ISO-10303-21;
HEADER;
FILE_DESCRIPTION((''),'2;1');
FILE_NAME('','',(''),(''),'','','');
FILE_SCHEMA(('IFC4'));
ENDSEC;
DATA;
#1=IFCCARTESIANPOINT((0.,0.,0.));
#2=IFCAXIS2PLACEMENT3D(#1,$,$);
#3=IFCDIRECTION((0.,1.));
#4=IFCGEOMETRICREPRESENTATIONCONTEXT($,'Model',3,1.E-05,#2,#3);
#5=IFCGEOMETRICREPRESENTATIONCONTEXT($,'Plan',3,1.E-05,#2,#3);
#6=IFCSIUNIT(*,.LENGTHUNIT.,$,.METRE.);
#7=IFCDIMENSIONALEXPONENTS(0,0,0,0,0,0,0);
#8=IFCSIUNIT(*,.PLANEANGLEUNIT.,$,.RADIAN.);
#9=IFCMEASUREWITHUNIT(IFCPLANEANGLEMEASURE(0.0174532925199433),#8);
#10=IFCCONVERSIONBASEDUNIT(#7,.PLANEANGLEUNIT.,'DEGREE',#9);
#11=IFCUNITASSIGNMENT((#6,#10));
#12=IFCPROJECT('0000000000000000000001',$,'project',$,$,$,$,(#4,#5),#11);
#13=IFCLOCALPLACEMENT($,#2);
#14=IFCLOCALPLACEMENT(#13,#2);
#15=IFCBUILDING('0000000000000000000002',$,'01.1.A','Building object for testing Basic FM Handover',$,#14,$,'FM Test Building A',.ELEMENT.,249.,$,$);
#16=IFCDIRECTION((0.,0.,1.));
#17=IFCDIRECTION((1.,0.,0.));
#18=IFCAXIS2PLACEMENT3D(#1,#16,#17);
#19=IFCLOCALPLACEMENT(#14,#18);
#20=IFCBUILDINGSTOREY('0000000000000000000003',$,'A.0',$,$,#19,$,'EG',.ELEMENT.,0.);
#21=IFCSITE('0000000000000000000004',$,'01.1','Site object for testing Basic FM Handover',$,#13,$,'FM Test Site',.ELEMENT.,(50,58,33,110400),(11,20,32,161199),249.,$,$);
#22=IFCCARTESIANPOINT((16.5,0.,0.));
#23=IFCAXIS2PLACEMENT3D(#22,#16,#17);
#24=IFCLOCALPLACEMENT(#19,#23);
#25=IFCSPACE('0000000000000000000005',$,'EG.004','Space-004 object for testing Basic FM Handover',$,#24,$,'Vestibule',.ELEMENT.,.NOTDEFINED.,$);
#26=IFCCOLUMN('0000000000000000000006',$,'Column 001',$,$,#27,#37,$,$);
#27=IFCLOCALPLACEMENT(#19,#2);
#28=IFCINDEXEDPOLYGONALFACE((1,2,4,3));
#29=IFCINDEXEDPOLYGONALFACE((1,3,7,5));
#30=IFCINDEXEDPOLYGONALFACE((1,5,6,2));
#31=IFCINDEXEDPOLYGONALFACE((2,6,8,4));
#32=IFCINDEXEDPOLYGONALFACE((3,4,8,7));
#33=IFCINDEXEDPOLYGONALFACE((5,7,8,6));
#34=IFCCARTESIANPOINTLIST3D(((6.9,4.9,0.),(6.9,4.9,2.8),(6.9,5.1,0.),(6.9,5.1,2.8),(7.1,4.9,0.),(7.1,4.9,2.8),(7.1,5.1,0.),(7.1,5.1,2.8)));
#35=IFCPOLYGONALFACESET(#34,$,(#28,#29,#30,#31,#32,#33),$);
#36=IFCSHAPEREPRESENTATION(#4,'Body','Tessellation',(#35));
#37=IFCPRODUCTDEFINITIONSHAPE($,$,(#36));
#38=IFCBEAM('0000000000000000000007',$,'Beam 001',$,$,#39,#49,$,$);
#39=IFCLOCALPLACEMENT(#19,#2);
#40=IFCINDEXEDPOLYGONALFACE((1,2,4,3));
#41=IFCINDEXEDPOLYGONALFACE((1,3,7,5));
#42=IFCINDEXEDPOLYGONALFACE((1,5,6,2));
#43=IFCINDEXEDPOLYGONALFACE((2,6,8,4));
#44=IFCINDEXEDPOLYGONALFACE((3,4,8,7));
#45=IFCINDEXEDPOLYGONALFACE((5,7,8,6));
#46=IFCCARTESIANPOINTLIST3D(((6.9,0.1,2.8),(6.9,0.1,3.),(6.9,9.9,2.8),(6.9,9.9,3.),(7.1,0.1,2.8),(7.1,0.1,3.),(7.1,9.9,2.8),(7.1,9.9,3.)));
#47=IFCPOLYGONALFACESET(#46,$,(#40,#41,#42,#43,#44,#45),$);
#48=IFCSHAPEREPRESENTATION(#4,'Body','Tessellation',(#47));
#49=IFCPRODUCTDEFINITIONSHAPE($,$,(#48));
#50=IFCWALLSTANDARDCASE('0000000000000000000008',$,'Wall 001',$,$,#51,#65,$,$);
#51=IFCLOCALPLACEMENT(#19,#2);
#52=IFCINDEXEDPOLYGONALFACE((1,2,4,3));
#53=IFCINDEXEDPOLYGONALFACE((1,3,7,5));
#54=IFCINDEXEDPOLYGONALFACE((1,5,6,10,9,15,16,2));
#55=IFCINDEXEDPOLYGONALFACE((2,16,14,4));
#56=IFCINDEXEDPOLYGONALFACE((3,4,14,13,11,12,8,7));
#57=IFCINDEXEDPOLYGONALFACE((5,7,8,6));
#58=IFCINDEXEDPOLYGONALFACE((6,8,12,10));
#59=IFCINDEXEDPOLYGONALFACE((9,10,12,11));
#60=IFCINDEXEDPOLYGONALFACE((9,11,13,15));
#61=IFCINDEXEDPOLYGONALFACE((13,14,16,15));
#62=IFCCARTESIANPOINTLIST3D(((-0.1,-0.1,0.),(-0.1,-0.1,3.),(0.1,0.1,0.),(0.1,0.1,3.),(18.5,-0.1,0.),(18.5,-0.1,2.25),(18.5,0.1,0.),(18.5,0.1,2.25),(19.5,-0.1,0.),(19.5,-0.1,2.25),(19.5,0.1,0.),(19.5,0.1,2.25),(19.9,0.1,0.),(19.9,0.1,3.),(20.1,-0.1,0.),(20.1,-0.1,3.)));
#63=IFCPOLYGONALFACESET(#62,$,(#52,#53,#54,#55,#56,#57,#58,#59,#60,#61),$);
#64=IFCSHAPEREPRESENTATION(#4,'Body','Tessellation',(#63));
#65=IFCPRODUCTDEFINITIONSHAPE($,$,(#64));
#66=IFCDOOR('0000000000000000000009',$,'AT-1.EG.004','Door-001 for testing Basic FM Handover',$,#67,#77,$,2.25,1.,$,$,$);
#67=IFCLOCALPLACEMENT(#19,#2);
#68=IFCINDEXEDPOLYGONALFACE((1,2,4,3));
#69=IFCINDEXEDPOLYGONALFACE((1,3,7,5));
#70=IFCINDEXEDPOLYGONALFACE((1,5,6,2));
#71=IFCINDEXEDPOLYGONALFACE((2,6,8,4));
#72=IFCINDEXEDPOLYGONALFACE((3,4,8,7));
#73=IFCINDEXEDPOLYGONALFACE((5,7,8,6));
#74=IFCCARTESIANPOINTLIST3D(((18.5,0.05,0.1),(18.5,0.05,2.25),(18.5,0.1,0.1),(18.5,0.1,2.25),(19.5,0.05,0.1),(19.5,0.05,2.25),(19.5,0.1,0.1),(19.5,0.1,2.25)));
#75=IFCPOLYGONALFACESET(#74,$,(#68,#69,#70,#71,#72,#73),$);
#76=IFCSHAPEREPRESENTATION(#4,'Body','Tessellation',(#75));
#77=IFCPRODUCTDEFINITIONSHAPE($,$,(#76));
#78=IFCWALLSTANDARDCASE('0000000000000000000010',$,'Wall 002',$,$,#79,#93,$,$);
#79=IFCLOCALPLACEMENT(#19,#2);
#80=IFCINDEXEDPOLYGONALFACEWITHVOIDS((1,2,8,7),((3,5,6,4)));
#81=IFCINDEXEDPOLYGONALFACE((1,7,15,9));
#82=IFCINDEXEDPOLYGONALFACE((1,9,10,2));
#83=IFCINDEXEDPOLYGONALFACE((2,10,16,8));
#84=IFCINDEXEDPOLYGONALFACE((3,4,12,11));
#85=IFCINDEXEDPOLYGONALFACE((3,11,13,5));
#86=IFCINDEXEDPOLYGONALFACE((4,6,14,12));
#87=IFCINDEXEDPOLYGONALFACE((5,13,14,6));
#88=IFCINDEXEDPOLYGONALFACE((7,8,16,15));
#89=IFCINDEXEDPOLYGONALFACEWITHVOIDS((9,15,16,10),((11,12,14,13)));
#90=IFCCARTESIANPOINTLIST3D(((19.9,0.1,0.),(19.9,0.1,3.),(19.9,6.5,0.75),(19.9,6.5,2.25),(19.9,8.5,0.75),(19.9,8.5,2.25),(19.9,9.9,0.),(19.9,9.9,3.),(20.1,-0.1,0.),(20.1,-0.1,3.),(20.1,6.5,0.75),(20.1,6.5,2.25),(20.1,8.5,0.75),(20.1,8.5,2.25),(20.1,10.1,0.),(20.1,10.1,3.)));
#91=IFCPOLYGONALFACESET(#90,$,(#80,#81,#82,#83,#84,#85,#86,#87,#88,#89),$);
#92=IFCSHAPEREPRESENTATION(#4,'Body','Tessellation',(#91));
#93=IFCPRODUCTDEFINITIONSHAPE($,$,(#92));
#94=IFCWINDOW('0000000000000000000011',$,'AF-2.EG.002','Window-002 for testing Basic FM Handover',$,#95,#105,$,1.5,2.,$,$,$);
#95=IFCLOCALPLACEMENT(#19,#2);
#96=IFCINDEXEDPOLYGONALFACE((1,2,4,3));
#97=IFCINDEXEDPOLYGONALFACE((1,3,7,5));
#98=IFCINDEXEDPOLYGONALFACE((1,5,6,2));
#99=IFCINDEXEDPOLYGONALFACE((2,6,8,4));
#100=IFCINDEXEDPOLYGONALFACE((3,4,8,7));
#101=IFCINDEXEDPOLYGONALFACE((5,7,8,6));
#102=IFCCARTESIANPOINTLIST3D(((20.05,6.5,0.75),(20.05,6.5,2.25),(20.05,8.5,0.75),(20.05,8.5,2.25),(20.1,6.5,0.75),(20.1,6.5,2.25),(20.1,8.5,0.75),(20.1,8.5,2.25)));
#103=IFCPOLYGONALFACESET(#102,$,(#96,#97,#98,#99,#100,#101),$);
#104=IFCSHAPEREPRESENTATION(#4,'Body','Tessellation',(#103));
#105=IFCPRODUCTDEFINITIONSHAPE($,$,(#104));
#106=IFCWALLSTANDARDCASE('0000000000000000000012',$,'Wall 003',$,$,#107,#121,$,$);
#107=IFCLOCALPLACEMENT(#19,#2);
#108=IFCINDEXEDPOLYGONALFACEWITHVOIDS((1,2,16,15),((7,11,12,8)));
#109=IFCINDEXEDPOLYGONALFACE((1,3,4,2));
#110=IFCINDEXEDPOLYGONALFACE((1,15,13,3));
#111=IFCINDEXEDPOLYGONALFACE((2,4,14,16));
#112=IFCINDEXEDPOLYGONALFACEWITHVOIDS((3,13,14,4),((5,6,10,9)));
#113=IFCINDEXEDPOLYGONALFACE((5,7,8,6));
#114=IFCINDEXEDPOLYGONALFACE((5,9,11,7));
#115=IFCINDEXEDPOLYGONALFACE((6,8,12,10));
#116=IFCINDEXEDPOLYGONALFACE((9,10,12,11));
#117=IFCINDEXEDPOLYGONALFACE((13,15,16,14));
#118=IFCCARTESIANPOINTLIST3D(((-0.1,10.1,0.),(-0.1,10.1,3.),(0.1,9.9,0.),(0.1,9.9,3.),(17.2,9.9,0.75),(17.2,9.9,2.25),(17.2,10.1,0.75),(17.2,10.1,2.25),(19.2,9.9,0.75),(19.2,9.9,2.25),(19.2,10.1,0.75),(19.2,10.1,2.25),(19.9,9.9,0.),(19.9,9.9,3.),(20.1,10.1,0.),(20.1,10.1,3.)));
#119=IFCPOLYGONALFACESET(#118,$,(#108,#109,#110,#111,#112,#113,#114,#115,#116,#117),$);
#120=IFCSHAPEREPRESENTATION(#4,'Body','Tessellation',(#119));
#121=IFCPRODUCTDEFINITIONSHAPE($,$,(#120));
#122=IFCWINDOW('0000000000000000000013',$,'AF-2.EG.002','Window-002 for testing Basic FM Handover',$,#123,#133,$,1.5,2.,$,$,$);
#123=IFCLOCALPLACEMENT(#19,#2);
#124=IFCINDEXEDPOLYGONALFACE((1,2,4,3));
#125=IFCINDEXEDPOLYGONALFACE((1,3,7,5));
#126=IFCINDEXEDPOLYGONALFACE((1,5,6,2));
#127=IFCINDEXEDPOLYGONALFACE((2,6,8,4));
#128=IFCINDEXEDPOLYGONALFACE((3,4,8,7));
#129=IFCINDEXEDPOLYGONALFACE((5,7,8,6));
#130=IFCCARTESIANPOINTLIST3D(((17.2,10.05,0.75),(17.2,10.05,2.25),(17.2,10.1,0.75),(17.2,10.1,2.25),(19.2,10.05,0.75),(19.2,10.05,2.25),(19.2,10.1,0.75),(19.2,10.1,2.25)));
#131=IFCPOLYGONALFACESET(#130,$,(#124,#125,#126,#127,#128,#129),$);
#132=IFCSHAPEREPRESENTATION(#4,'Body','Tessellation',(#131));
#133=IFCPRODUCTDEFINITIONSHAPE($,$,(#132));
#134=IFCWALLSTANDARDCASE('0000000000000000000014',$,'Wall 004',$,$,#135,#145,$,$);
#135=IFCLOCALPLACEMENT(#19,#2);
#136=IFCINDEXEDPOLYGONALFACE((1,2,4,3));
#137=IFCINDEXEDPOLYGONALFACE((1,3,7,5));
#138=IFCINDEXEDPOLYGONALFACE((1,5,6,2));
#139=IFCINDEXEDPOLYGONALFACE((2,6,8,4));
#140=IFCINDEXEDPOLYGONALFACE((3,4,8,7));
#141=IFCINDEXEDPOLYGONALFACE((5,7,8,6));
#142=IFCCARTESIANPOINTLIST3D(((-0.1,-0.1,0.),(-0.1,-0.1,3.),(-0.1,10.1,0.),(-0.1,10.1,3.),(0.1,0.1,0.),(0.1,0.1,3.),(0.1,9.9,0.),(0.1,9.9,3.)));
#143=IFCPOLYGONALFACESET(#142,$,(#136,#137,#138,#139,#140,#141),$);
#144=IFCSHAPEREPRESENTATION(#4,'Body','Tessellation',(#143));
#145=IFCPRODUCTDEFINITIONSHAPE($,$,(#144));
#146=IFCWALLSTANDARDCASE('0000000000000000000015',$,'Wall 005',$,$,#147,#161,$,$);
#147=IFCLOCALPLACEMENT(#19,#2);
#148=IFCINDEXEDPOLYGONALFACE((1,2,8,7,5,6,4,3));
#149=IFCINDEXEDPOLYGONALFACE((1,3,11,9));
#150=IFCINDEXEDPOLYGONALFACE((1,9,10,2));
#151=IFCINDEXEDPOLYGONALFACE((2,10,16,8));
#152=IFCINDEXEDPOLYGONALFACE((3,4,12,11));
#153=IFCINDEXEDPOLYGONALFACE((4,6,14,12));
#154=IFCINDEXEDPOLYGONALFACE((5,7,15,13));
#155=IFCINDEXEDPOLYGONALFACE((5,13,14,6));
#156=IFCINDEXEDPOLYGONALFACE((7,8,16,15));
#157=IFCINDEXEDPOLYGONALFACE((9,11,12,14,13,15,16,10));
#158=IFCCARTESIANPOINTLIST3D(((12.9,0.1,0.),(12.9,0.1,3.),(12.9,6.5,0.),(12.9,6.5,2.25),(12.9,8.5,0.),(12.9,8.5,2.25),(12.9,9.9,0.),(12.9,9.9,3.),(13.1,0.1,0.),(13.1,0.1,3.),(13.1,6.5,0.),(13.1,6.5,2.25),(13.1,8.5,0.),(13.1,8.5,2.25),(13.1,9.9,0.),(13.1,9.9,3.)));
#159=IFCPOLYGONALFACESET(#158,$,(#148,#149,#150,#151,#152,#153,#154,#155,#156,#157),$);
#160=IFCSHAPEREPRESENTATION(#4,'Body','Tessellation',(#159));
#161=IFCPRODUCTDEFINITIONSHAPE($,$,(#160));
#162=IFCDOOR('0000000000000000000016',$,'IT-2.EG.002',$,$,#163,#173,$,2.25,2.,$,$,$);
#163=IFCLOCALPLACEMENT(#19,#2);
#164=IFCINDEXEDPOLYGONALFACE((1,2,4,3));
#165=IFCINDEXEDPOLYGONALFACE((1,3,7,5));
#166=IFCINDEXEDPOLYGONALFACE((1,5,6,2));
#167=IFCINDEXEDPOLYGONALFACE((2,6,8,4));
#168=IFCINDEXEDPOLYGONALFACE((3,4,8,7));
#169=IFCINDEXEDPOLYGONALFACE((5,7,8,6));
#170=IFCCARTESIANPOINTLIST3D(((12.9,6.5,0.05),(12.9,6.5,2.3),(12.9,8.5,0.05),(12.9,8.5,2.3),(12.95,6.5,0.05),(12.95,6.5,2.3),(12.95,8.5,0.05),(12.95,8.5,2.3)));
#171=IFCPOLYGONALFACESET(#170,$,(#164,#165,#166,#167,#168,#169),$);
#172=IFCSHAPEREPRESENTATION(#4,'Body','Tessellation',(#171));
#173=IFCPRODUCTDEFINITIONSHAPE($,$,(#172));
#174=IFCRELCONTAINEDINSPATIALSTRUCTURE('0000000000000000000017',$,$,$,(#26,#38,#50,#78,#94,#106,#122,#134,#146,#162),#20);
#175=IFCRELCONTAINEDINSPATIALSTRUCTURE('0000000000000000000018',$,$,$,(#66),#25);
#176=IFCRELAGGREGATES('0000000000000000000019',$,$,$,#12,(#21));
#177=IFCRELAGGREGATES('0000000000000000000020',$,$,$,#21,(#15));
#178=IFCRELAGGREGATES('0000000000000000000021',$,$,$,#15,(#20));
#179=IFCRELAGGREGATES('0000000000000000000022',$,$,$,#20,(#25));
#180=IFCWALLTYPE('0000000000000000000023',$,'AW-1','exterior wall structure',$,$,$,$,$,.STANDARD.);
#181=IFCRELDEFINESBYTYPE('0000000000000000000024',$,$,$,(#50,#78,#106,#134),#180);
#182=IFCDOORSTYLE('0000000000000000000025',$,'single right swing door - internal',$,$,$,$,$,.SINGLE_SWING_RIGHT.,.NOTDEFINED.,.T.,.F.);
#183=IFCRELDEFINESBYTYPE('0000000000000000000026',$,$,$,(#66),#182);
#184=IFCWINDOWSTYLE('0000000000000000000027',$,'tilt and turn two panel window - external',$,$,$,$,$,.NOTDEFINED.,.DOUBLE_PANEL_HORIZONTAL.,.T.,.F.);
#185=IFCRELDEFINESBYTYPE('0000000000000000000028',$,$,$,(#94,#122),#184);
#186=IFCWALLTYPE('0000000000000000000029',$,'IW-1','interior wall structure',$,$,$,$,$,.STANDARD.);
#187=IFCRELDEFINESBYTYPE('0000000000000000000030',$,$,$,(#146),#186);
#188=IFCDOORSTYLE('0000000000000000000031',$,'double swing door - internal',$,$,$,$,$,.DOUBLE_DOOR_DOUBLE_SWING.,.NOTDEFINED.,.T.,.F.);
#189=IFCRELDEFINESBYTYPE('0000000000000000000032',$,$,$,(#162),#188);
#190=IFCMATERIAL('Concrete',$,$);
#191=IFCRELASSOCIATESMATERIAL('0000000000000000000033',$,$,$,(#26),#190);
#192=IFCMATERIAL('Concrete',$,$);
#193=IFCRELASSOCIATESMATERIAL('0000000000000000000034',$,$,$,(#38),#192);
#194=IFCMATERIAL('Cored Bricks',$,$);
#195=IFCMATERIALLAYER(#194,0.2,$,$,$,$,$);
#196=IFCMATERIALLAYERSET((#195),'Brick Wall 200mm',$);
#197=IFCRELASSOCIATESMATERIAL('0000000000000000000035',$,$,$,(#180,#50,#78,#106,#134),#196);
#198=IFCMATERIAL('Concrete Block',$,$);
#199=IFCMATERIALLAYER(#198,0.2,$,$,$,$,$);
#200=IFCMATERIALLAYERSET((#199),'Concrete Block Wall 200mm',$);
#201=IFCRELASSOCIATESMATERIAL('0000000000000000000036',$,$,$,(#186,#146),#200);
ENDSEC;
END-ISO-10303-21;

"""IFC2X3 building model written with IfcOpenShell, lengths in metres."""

from ifc_helpers import new_model, entity, si_unit, converted_unit, direction, frame, frame_2d, origin, origin_with_axes, origin_2d, place, context, project, spatial, polyline, rectangle, outline, extrude, material, layer, layer_set, layer_usage, type_object, element, fill, save


model = new_model("IFC2X3")

# Units and contexts
model_context = context("Model", 3, precision=1e-05, world=origin(), true_north=direction((0.0, 1.0)))
plan_context = context("Plan", 3, precision=1e-05, world=origin(), true_north=direction((0.0, 1.0)))
ifc_project = project(units=[si_unit("LENGTHUNIT", "METRE"), converted_unit("PLANEANGLEUNIT", "DEGREE", entity("IfcPlaneAngleMeasure", 0.0174532925199433), si_unit("PLANEANGLEUNIT", "RADIAN"), dimensions=[0, 0, 0, 0, 0, 0, 0])], contexts=[model_context, plan_context])

# Site, building, storey
site_placement = place(None, origin())
site = spatial("IfcSite", under=ifc_project, at=site_placement, Name="01.1", Description="Site object for testing Basic FM Handover", LongName="FM Test Site", CompositionType="ELEMENT", RefLatitude=(50, 58, 33, 110400), RefLongitude=(11, 20, 32, 161199), RefElevation=249.0)
building_placement = place(site_placement, origin())
building = spatial("IfcBuilding", under=site, at=building_placement, Name="01.1.A", Description="Building object for testing Basic FM Handover", LongName="FM Test Building A", CompositionType="ELEMENT", ElevationOfRefHeight=249.0)
storey_placement = place(building_placement, origin_with_axes())
storey = spatial("IfcBuildingStorey", under=building, at=storey_placement, Name="A.0", LongName="EG", CompositionType="ELEMENT", Elevation=0.0)

# Column
ifc_material_1 = material(Name="Concrete")
column_placement = place(storey_placement, frame((7.0, 5.0, 0.0), z_axis=(0.0, 0.0, 1.0), x_axis=(1.0, 0.0, 0.0)))
element("IfcColumn", 1, at=column_placement, inside=storey, material=ifc_material_1, Name="Column 001", context=model_context, shape_type="SweptSolid", body=[
    extrude(rectangle(XDim=0.2, YDim=0.2, at=origin_2d()), origin(), (0.0, 0.0, 1.0), 2.8),
])

# Beam
ifc_material_2 = material(Name="Concrete")
beam_placement = place(storey_placement, frame((7.0, 9.9, 2.9), z_axis=(0.0, -1.0, 0.0), x_axis=(1.0, 0.0, 0.0)))
element("IfcBeam", 2, at=beam_placement, inside=storey, material=ifc_material_2, Name="Beam 001", context=model_context, shape_type="SweptSolid", body=[
    extrude(rectangle(XDim=0.2, YDim=0.2, at=origin_2d()), origin(), (0.0, 0.0, 1.0), 9.8),
])

# Wall, opening
ifc_material_3 = material(Name="Cored Bricks")
ifc_layer_1 = layer(ifc_material_3, 0.2)
ifc_layer_set_1 = layer_set([ifc_layer_1], Name="Brick Wall 200mm")
ifc_layer_usage_1 = layer_usage(ifc_layer_set_1, "AXIS2", "POSITIVE", -0.1)
wall_type_1 = type_object("IfcWallType", Name="AW-1", Description="exterior wall structure", PredefinedType="STANDARD", material=ifc_layer_set_1)
wall_1_placement = place(storey_placement, origin_with_axes())
wall_1 = element("IfcWallStandardCase", 3, at=wall_1_placement, inside=storey, type_object=wall_type_1, material=ifc_layer_usage_1, Name="Wall 001", context=model_context, shape_type="SweptSolid", body=[
    extrude(outline(polyline([(-0.1, -0.1), (20.1, -0.1), (19.9, 0.1), (0.1, 0.1), (-0.1, -0.1)])), origin(), (0.0, 0.0, 1.0), 3.0),
])
opening_1_placement = place(wall_1_placement, frame((18.5, -0.1, 0.0), z_axis=(0.0, 1.0, 0.0), x_axis=(0.0, 0.0, 1.0)))
opening_1 = element("IfcOpeningElement", 4, at=opening_1_placement, cuts=wall_1, context=model_context, shape_type="SweptSolid", body=[
    extrude(rectangle(XDim=2.25, YDim=1.0, at=frame_2d((1.125, 0.5))), origin(), (0.0, 0.0, 1.0), 0.2),
])

# Shared definitions
space_1_placement = place(storey_placement, frame((16.5, 0.0, 0.0), z_axis=(0.0, 0.0, 1.0), x_axis=(1.0, 0.0, 0.0)))
space_1 = spatial("IfcSpace", under=storey, at=space_1_placement, Name="EG.004", Description="Space-004 object for testing Basic FM Handover", LongName="Vestibule", CompositionType="ELEMENT", InteriorOrExteriorSpace="NOTDEFINED")

# Door
door_style_1 = type_object("IfcDoorStyle", Name="single right swing door - internal", ConstructionType="NOTDEFINED", OperationType="SINGLE_SWING_RIGHT", ParameterTakesPrecedence=True, Sizeable=False)
door_1_placement = place(opening_1_placement, frame((0.0, 0.0, 0.0), z_axis=(1.0, 0.0, 0.0), x_axis=(0.0, 1.0, 0.0)))
door_1 = element("IfcDoor", 5, at=door_1_placement, inside=space_1, type_object=door_style_1, Name="AT-1.EG.004", Description="Door-001 for testing Basic FM Handover", OverallHeight=2.25, OverallWidth=1.0, context=model_context, shape_type="SweptSolid", body=[
    extrude(rectangle(XDim=2.15, YDim=1.0, at=frame_2d((1.075, 0.5))), frame((0.0, 0.15, 0.1), z_axis=(0.0, 1.0, 0.0), x_axis=(0.0, 0.0, 1.0)), (0.0, 0.0, 1.0), 0.05),
])
fill(opening_1, door_1)

# Walls, openings, windows
ifc_layer_usage_2 = layer_usage(ifc_layer_set_1, "AXIS2", "POSITIVE", -0.1)
wall_2_placement = place(storey_placement, frame((20.0, 0.0, 0.0), z_axis=(0.0, 0.0, 1.0), x_axis=(0.0, 1.0, 0.0)))
wall_2 = element("IfcWallStandardCase", 6, at=wall_2_placement, inside=storey, type_object=wall_type_1, material=ifc_layer_usage_2, Name="Wall 002", context=model_context, shape_type="SweptSolid", body=[
    extrude(outline(polyline([(-0.1, -0.1), (10.1, -0.1), (9.9, 0.1), (0.1, 0.1), (-0.1, -0.1)])), origin(), (0.0, 0.0, 1.0), 3.0),
])
opening_2_placement = place(wall_2_placement, frame((6.5, -0.1, 0.75), z_axis=(0.0, 0.0, 1.0), x_axis=(1.0, 0.0, 0.0)))
opening_2 = element("IfcOpeningElement", 7, at=opening_2_placement, cuts=wall_2, context=model_context, shape_type="SweptSolid", body=[
    extrude(rectangle(XDim=1.5, YDim=2.0, at=frame_2d((0.75, 1.0))), frame((0.0, 0.0, 0.0), z_axis=(0.0, 1.0, 0.0), x_axis=(0.0, 0.0, 1.0)), (0.0, 0.0, 1.0), 0.2),
])
window_style = type_object("IfcWindowStyle", Name="tilt and turn two panel window - external", ConstructionType="NOTDEFINED", OperationType="DOUBLE_PANEL_HORIZONTAL", ParameterTakesPrecedence=True, Sizeable=False)
window_1_placement = place(opening_2_placement, origin_with_axes())
window_1 = element("IfcWindow", 8, at=window_1_placement, inside=storey, type_object=window_style, Name="AF-2.EG.002", Description="Window-002 for testing Basic FM Handover", OverallHeight=1.5, OverallWidth=2.0, context=model_context, shape_type="SweptSolid", body=[
    extrude(rectangle(XDim=1.5, YDim=2.0, at=frame_2d((0.75, 1.0))), frame((0.0, 0.0, 0.0), z_axis=(0.0, 1.0, 0.0), x_axis=(0.0, 0.0, 1.0)), (0.0, 0.0, 1.0), 0.05),
])
fill(opening_2, window_1)
ifc_layer_usage_3 = layer_usage(ifc_layer_set_1, "AXIS2", "POSITIVE", -0.1)
wall_3_placement = place(storey_placement, frame((20.0, 10.0, 0.0), z_axis=(0.0, 0.0, 1.0), x_axis=(-1.0, 0.0, 0.0)))
wall_3 = element("IfcWallStandardCase", 9, at=wall_3_placement, inside=storey, type_object=wall_type_1, material=ifc_layer_usage_3, Name="Wall 003", context=model_context, shape_type="SweptSolid", body=[
    extrude(outline(polyline([(-0.1, -0.1), (20.1, -0.1), (19.9, 0.1), (0.1, 0.1), (-0.1, -0.1)])), origin(), (0.0, 0.0, 1.0), 3.0),
])
opening_3_placement = place(wall_3_placement, frame((0.8, -0.1, 0.75), z_axis=(0.0, 0.0, 1.0), x_axis=(1.0, 0.0, 0.0)))
opening_3 = element("IfcOpeningElement", 10, at=opening_3_placement, cuts=wall_3, context=model_context, shape_type="SweptSolid", body=[
    extrude(rectangle(XDim=1.5, YDim=2.0, at=frame_2d((0.75, 1.0))), frame((0.0, 0.0, 0.0), z_axis=(0.0, 1.0, 0.0), x_axis=(0.0, 0.0, 1.0)), (0.0, 0.0, 1.0), 0.2),
])
window_2_placement = place(opening_3_placement, origin_with_axes())
window_2 = element("IfcWindow", 11, at=window_2_placement, inside=storey, type_object=window_style, Name="AF-2.EG.002", Description="Window-002 for testing Basic FM Handover", OverallHeight=1.5, OverallWidth=2.0, context=model_context, shape_type="SweptSolid", body=[
    extrude(rectangle(XDim=1.5, YDim=2.0, at=frame_2d((0.75, 1.0))), frame((0.0, 0.0, 0.0), z_axis=(0.0, 1.0, 0.0), x_axis=(0.0, 0.0, 1.0)), (0.0, 0.0, 1.0), 0.05),
])
fill(opening_3, window_2)

# Wall
ifc_layer_usage_4 = layer_usage(ifc_layer_set_1, "AXIS2", "POSITIVE", -0.1)
wall_4_placement = place(storey_placement, frame((0.0, 10.0, 0.0), z_axis=(0.0, 0.0, 1.0), x_axis=(0.0, -1.0, 0.0)))
element("IfcWallStandardCase", 12, at=wall_4_placement, inside=storey, type_object=wall_type_1, material=ifc_layer_usage_4, Name="Wall 004", context=model_context, shape_type="SweptSolid", body=[
    extrude(outline(polyline([(-0.1, -0.1), (10.1, -0.1), (9.9, 0.1), (0.1, 0.1), (-0.1, -0.1)])), origin(), (0.0, 0.0, 1.0), 3.0),
])

# Wall, opening, door
ifc_material_4 = material(Name="Concrete Block")
ifc_layer_2 = layer(ifc_material_4, 0.2)
ifc_layer_set_2 = layer_set([ifc_layer_2], Name="Concrete Block Wall 200mm")
ifc_layer_usage_5 = layer_usage(ifc_layer_set_2, "AXIS2", "POSITIVE", -0.1)
wall_type_2 = type_object("IfcWallType", Name="IW-1", Description="interior wall structure", PredefinedType="STANDARD", material=ifc_layer_set_2)
wall_5_placement = place(storey_placement, frame((13.0, 0.0, 0.0), z_axis=(0.0, 0.0, 1.0), x_axis=(0.0, 1.0, 0.0)))
wall_5 = element("IfcWallStandardCase", 13, at=wall_5_placement, inside=storey, type_object=wall_type_2, material=ifc_layer_usage_5, Name="Wall 005", context=model_context, shape_type="SweptSolid", body=[
    extrude(outline(polyline([(0.1, -0.1), (9.9, -0.1), (9.9, 0.1), (0.1, 0.1), (0.1, -0.1)])), origin(), (0.0, 0.0, 1.0), 3.0),
])
opening_4_placement = place(wall_5_placement, frame((6.5, -0.1, 0.0), z_axis=(0.0, 0.0, 1.0), x_axis=(1.0, 0.0, 0.0)))
opening_4 = element("IfcOpeningElement", 14, at=opening_4_placement, cuts=wall_5, context=model_context, shape_type="SweptSolid", body=[
    extrude(rectangle(XDim=2.25, YDim=2.0, at=frame_2d((1.125, 1.0))), frame((0.0, 0.0, 0.0), z_axis=(0.0, 1.0, 0.0), x_axis=(0.0, 0.0, 1.0)), (0.0, 0.0, 1.0), 0.2),
])
door_style_2 = type_object("IfcDoorStyle", Name="double swing door - internal", ConstructionType="NOTDEFINED", OperationType="DOUBLE_DOOR_DOUBLE_SWING", ParameterTakesPrecedence=True, Sizeable=False)
door_2_placement = place(opening_4_placement, origin_with_axes())
door_2 = element("IfcDoor", 15, at=door_2_placement, inside=storey, type_object=door_style_2, Name="IT-2.EG.002", OverallHeight=2.25, OverallWidth=2.0, context=model_context, shape_type="SweptSolid", body=[
    extrude(rectangle(XDim=2.25, YDim=2.0, at=frame_2d((1.075, 1.0))), frame((0.0, 0.15, 0.1), z_axis=(0.0, 1.0, 0.0), x_axis=(0.0, 0.0, 1.0)), (0.0, 0.0, 1.0), 0.05),
])
fill(opening_4, door_2)

save(model, "model.ifc")
